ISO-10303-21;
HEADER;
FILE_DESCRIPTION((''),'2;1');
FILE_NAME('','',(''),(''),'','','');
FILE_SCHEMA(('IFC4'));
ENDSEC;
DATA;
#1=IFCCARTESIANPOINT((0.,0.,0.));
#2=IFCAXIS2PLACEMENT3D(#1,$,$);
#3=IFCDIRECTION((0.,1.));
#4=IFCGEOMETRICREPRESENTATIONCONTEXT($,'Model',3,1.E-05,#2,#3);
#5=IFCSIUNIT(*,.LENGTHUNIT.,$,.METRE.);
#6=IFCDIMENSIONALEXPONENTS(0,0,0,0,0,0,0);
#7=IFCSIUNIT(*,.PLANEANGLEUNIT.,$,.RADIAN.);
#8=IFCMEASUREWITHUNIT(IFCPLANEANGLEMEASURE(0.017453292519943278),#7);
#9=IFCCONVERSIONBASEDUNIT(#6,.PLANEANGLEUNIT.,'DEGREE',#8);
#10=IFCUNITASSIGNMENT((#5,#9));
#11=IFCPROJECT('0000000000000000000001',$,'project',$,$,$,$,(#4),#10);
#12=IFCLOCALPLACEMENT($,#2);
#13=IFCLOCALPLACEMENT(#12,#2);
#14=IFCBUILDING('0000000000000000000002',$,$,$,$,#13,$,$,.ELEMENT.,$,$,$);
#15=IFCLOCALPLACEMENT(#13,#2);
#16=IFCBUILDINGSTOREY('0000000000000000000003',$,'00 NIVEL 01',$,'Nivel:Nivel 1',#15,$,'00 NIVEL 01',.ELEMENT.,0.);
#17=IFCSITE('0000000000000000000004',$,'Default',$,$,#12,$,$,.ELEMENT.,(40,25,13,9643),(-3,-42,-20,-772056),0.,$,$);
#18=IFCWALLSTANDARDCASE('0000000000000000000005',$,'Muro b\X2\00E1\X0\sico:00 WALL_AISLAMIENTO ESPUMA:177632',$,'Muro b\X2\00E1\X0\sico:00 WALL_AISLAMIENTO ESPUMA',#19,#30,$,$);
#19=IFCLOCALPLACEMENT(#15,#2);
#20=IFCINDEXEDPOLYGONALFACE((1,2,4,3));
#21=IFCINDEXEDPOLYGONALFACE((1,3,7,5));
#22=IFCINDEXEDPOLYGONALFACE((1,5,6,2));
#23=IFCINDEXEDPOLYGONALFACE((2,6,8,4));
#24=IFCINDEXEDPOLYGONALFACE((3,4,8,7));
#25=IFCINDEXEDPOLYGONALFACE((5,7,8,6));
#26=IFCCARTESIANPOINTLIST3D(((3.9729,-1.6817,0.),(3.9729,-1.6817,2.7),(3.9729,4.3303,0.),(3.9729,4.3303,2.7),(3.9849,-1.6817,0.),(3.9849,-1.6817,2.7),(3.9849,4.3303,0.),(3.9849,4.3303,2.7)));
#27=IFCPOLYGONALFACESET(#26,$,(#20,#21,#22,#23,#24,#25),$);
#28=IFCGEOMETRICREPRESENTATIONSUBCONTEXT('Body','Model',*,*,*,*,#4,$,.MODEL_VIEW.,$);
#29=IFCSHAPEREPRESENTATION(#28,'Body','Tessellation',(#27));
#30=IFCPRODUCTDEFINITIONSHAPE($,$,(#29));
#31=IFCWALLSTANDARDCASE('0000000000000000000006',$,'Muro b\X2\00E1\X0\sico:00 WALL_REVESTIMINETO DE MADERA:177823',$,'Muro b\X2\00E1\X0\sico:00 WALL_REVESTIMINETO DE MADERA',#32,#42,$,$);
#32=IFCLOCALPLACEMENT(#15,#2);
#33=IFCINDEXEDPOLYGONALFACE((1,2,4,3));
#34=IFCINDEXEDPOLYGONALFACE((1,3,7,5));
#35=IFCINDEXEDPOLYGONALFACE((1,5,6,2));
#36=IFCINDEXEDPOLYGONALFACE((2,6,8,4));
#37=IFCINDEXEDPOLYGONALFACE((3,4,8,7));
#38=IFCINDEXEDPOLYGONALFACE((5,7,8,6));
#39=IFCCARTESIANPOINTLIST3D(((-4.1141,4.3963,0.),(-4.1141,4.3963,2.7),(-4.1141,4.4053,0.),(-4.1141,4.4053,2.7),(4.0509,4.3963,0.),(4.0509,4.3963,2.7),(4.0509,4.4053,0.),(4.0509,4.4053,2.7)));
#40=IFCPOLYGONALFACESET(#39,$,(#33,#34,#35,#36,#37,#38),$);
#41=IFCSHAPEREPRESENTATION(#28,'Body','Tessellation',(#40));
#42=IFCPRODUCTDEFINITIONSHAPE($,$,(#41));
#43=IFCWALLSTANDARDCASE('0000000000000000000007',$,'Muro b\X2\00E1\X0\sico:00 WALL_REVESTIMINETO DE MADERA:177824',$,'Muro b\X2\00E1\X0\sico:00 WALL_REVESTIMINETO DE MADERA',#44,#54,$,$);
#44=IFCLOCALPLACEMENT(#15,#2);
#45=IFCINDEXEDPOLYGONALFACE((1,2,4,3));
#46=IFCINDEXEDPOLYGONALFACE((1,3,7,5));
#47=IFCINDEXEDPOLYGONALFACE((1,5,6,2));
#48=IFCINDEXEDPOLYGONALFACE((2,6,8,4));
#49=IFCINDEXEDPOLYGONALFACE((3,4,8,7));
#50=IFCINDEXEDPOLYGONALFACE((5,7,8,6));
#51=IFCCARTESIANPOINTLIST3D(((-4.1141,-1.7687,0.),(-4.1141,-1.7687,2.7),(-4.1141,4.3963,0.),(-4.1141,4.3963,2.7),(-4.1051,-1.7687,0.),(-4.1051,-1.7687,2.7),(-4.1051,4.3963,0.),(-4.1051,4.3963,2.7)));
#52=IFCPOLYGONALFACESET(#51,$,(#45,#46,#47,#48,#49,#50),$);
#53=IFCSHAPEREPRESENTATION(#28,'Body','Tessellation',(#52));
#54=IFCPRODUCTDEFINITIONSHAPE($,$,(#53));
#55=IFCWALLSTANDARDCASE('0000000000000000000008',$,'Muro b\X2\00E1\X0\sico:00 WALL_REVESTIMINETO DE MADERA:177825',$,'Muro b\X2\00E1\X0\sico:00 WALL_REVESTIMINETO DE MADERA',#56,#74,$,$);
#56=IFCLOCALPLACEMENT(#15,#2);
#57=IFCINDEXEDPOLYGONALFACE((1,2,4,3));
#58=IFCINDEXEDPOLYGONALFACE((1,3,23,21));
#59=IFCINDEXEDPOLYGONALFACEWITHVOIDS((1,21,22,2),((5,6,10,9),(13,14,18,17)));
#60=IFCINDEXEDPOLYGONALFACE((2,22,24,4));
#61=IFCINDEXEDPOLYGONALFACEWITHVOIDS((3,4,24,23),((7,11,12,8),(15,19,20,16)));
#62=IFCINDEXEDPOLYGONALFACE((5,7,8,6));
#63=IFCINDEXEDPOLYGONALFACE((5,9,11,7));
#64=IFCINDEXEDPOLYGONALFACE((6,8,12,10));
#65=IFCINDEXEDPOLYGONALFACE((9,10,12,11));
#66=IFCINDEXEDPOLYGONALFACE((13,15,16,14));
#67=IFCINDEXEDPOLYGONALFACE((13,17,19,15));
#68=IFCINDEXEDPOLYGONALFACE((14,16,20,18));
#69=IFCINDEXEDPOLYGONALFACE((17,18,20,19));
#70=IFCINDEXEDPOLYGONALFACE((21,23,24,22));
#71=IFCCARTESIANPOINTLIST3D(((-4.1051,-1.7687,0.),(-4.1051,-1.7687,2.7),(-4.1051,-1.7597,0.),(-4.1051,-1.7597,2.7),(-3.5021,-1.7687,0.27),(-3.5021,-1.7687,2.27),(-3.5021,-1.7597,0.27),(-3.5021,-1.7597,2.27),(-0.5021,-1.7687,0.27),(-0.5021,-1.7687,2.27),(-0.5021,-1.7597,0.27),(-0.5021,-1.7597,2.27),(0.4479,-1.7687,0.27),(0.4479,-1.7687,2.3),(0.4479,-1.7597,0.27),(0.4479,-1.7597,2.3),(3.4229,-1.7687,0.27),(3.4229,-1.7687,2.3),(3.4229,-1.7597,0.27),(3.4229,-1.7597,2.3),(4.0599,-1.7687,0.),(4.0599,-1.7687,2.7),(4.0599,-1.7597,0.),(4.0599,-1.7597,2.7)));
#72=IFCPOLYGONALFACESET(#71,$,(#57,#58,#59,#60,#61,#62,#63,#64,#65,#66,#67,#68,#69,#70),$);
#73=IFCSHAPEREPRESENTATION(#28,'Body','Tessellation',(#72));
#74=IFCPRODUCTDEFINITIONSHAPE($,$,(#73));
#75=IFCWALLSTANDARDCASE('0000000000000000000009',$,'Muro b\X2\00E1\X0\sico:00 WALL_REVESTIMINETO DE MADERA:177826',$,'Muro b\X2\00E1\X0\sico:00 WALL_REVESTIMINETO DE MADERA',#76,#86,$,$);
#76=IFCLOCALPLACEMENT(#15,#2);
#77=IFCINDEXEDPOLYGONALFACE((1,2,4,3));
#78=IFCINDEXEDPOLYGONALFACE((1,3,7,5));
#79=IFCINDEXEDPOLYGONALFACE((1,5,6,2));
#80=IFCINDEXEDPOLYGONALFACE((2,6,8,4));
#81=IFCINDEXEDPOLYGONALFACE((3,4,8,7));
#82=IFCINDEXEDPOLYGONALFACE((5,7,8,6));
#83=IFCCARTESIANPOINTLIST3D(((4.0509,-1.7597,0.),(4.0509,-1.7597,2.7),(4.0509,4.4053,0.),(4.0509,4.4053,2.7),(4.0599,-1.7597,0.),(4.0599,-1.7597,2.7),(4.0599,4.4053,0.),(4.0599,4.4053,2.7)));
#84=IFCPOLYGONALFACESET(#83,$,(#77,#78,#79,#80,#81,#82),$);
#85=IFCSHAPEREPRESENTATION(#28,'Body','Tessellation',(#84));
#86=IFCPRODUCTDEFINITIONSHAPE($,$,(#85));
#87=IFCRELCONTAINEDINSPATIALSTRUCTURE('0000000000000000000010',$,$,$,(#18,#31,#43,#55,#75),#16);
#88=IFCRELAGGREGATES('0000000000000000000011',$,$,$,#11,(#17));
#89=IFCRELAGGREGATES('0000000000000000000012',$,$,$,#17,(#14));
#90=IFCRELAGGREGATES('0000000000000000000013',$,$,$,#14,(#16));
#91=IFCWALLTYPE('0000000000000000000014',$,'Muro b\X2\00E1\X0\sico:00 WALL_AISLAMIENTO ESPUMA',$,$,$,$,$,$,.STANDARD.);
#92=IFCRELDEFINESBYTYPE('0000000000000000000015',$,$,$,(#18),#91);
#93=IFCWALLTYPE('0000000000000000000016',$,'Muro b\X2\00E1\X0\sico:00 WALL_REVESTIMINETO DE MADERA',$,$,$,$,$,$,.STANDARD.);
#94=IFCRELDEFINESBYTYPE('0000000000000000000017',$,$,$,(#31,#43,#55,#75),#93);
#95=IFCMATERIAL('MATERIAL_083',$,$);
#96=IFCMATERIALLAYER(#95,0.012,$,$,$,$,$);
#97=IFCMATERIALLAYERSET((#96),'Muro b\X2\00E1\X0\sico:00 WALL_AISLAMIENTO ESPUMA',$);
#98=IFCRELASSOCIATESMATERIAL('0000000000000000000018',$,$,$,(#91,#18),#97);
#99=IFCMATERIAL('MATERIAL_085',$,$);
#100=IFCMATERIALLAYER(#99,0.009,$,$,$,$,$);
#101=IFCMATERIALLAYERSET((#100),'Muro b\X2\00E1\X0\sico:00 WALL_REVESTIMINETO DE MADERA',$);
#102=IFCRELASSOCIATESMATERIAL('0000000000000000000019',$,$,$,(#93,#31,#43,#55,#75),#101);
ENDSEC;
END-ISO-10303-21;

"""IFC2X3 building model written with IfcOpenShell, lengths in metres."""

from ifc_helpers import new_model, entity, si_unit, converted_unit, direction, frame, frame_2d, origin, place, context, subcontext, project, spatial, rectangle, extrude, material, layer, layer_set, layer_usage, type_object, element, save


model = new_model("IFC2X3")

# Units and contexts
model_context = context("Model", 3, precision=1e-05, world=origin(), true_north=direction((0.0, 1.0)))
body_context = subcontext(model_context, "Body", "Model", "MODEL_VIEW")
ifc_project = project(units=[si_unit("LENGTHUNIT", "METRE"), converted_unit("PLANEANGLEUNIT", "DEGREE", entity("IfcPlaneAngleMeasure", 0.017453292519943278), si_unit("PLANEANGLEUNIT", "RADIAN"), dimensions=[0, 0, 0, 0, 0, 0, 0])], contexts=[model_context])

# Site, building, storey
site_placement = place(None, origin())
site = spatial("IfcSite", under=ifc_project, at=site_placement, Name="Default", CompositionType="ELEMENT", RefLatitude=(40, 25, 13, 9643), RefLongitude=(-3, -42, -20, -772056), RefElevation=0.0)
building_placement = place(site_placement, origin())
building = spatial("IfcBuilding", under=site, at=building_placement, CompositionType="ELEMENT")
storey_placement = place(building_placement, origin())
storey = spatial("IfcBuildingStorey", under=building, at=storey_placement, Name="00 NIVEL 01", ObjectType="Nivel:Nivel 1", LongName="00 NIVEL 01", CompositionType="ELEMENT", Elevation=0.0)

# Shared definitions
ifc_material_1 = material(Name="MATERIAL_083")
ifc_layer_1 = layer(ifc_material_1, 0.012)
ifc_layer_set_1 = layer_set([ifc_layer_1], Name="Muro básico:00 WALL_AISLAMIENTO ESPUMA")
wall_type_1 = type_object("IfcWallType", Name="Muro básico:00 WALL_AISLAMIENTO ESPUMA", PredefinedType="STANDARD", material=ifc_layer_set_1)

# Walls
ifc_layer_usage_1 = layer_usage(ifc_layer_set_1, "AXIS2", "NEGATIVE", 0.006)
wall_1_placement = place(storey_placement, frame((3.9789, 4.3303, 0.0), z_axis=(0.0, 0.0, 1.0), x_axis=(0.0, -1.0, 0.0)))
element("IfcWallStandardCase", 1, at=wall_1_placement, inside=storey, type_object=wall_type_1, material=ifc_layer_usage_1, Name="Muro básico:00 WALL_AISLAMIENTO ESPUMA:177632", ObjectType="Muro básico:00 WALL_AISLAMIENTO ESPUMA", context=body_context, shape_type="SweptSolid", body=[
    extrude(rectangle(XDim=6.012, YDim=0.012, at=frame_2d((3.006, 0.0), x_axis=(-1.0, 0.0))), origin(), (0.0, 0.0, 1.0), 2.7),
])
ifc_material_2 = material(Name="MATERIAL_085")
ifc_layer_2 = layer(ifc_material_2, 0.009)
ifc_layer_set_2 = layer_set([ifc_layer_2], Name="Muro básico:00 WALL_REVESTIMINETO DE MADERA")
ifc_layer_usage_2 = layer_usage(ifc_layer_set_2, "AXIS2", "NEGATIVE", 0.0045)
wall_type_2 = type_object("IfcWallType", Name="Muro básico:00 WALL_REVESTIMINETO DE MADERA", PredefinedType="STANDARD", material=ifc_layer_set_2)
wall_2_placement = place(storey_placement, frame((-4.1141, 4.4008, 0.0)))
element("IfcWallStandardCase", 2, at=wall_2_placement, inside=storey, type_object=wall_type_2, material=ifc_layer_usage_2, Name="Muro básico:00 WALL_REVESTIMINETO DE MADERA:177823", ObjectType="Muro básico:00 WALL_REVESTIMINETO DE MADERA", context=body_context, shape_type="SweptSolid", body=[
    extrude(rectangle(XDim=8.165, YDim=0.009, at=frame_2d((4.0825, 0.0), x_axis=(-1.0, 0.0))), origin(), (0.0, 0.0, 1.0), 2.7),
])
ifc_layer_usage_3 = layer_usage(ifc_layer_set_2, "AXIS2", "NEGATIVE", 0.0045)
wall_3_placement = place(storey_placement, frame((-4.1096, -1.7687, 0.0), z_axis=(0.0, 0.0, 1.0), x_axis=(0.0, 1.0, 0.0)))
element("IfcWallStandardCase", 3, at=wall_3_placement, inside=storey, type_object=wall_type_2, material=ifc_layer_usage_3, Name="Muro básico:00 WALL_REVESTIMINETO DE MADERA:177824", ObjectType="Muro básico:00 WALL_REVESTIMINETO DE MADERA", context=body_context, shape_type="SweptSolid", body=[
    extrude(rectangle(XDim=6.165, YDim=0.009, at=frame_2d((3.0825, 0.0), x_axis=(-1.0, 0.0))), origin(), (0.0, 0.0, 1.0), 2.7),
])

# Wall, openings
ifc_layer_usage_4 = layer_usage(ifc_layer_set_2, "AXIS2", "NEGATIVE", 0.0045)
wall_4_placement = place(storey_placement, frame((4.0599, -1.7642, 0.0), z_axis=(0.0, 0.0, 1.0), x_axis=(-1.0, 0.0, 0.0)))
wall_4 = element("IfcWallStandardCase", 4, at=wall_4_placement, inside=storey, type_object=wall_type_2, material=ifc_layer_usage_4, Name="Muro básico:00 WALL_REVESTIMINETO DE MADERA:177825", ObjectType="Muro básico:00 WALL_REVESTIMINETO DE MADERA", context=body_context, shape_type="SweptSolid", body=[
    extrude(rectangle(XDim=8.165, YDim=0.009, at=frame_2d((4.0825, 0.0), x_axis=(-1.0, 0.0))), origin(), (0.0, 0.0, 1.0), 2.7),
])
opening_1_placement = place(wall_4_placement, origin())
element("IfcOpeningElement", 5, at=opening_1_placement, cuts=wall_4, ObjectType="Opening", context=body_context, shape_type="SweptSolid", body=[
    extrude(rectangle(XDim=2.0, YDim=3.0, at=frame_2d((0.0, 0.0), x_axis=(1.0, 0.0))), frame((6.062, 0.0045, 1.27), z_axis=(0.0, -1.0, 0.0), x_axis=(0.0, 0.0, -1.0)), (0.0, 0.0, 1.0), 0.009),
])
opening_2_placement = place(wall_4_placement, origin())
element("IfcOpeningElement", 6, at=opening_2_placement, cuts=wall_4, ObjectType="Opening", context=body_context, shape_type="SweptSolid", body=[
    extrude(rectangle(XDim=2.03, YDim=2.975, at=frame_2d((0.0, 0.0), x_axis=(1.0, 0.0))), frame((2.1245, 0.0045, 1.285), z_axis=(0.0, -1.0, 0.0), x_axis=(0.0, 0.0, -1.0)), (0.0, 0.0, 1.0), 0.009),
])

# Wall
ifc_layer_usage_5 = layer_usage(ifc_layer_set_2, "AXIS2", "NEGATIVE", 0.0045)
wall_5_placement = place(storey_placement, frame((4.0554, 4.4053, 0.0), z_axis=(0.0, 0.0, 1.0), x_axis=(0.0, -1.0, 0.0)))
element("IfcWallStandardCase", 7, at=wall_5_placement, inside=storey, type_object=wall_type_2, material=ifc_layer_usage_5, Name="Muro básico:00 WALL_REVESTIMINETO DE MADERA:177826", ObjectType="Muro básico:00 WALL_REVESTIMINETO DE MADERA", context=body_context, shape_type="SweptSolid", body=[
    extrude(rectangle(XDim=6.165, YDim=0.009, at=frame_2d((3.0825, 0.0), x_axis=(-1.0, 0.0))), origin(), (0.0, 0.0, 1.0), 2.7),
])

save(model, "model.ifc")
